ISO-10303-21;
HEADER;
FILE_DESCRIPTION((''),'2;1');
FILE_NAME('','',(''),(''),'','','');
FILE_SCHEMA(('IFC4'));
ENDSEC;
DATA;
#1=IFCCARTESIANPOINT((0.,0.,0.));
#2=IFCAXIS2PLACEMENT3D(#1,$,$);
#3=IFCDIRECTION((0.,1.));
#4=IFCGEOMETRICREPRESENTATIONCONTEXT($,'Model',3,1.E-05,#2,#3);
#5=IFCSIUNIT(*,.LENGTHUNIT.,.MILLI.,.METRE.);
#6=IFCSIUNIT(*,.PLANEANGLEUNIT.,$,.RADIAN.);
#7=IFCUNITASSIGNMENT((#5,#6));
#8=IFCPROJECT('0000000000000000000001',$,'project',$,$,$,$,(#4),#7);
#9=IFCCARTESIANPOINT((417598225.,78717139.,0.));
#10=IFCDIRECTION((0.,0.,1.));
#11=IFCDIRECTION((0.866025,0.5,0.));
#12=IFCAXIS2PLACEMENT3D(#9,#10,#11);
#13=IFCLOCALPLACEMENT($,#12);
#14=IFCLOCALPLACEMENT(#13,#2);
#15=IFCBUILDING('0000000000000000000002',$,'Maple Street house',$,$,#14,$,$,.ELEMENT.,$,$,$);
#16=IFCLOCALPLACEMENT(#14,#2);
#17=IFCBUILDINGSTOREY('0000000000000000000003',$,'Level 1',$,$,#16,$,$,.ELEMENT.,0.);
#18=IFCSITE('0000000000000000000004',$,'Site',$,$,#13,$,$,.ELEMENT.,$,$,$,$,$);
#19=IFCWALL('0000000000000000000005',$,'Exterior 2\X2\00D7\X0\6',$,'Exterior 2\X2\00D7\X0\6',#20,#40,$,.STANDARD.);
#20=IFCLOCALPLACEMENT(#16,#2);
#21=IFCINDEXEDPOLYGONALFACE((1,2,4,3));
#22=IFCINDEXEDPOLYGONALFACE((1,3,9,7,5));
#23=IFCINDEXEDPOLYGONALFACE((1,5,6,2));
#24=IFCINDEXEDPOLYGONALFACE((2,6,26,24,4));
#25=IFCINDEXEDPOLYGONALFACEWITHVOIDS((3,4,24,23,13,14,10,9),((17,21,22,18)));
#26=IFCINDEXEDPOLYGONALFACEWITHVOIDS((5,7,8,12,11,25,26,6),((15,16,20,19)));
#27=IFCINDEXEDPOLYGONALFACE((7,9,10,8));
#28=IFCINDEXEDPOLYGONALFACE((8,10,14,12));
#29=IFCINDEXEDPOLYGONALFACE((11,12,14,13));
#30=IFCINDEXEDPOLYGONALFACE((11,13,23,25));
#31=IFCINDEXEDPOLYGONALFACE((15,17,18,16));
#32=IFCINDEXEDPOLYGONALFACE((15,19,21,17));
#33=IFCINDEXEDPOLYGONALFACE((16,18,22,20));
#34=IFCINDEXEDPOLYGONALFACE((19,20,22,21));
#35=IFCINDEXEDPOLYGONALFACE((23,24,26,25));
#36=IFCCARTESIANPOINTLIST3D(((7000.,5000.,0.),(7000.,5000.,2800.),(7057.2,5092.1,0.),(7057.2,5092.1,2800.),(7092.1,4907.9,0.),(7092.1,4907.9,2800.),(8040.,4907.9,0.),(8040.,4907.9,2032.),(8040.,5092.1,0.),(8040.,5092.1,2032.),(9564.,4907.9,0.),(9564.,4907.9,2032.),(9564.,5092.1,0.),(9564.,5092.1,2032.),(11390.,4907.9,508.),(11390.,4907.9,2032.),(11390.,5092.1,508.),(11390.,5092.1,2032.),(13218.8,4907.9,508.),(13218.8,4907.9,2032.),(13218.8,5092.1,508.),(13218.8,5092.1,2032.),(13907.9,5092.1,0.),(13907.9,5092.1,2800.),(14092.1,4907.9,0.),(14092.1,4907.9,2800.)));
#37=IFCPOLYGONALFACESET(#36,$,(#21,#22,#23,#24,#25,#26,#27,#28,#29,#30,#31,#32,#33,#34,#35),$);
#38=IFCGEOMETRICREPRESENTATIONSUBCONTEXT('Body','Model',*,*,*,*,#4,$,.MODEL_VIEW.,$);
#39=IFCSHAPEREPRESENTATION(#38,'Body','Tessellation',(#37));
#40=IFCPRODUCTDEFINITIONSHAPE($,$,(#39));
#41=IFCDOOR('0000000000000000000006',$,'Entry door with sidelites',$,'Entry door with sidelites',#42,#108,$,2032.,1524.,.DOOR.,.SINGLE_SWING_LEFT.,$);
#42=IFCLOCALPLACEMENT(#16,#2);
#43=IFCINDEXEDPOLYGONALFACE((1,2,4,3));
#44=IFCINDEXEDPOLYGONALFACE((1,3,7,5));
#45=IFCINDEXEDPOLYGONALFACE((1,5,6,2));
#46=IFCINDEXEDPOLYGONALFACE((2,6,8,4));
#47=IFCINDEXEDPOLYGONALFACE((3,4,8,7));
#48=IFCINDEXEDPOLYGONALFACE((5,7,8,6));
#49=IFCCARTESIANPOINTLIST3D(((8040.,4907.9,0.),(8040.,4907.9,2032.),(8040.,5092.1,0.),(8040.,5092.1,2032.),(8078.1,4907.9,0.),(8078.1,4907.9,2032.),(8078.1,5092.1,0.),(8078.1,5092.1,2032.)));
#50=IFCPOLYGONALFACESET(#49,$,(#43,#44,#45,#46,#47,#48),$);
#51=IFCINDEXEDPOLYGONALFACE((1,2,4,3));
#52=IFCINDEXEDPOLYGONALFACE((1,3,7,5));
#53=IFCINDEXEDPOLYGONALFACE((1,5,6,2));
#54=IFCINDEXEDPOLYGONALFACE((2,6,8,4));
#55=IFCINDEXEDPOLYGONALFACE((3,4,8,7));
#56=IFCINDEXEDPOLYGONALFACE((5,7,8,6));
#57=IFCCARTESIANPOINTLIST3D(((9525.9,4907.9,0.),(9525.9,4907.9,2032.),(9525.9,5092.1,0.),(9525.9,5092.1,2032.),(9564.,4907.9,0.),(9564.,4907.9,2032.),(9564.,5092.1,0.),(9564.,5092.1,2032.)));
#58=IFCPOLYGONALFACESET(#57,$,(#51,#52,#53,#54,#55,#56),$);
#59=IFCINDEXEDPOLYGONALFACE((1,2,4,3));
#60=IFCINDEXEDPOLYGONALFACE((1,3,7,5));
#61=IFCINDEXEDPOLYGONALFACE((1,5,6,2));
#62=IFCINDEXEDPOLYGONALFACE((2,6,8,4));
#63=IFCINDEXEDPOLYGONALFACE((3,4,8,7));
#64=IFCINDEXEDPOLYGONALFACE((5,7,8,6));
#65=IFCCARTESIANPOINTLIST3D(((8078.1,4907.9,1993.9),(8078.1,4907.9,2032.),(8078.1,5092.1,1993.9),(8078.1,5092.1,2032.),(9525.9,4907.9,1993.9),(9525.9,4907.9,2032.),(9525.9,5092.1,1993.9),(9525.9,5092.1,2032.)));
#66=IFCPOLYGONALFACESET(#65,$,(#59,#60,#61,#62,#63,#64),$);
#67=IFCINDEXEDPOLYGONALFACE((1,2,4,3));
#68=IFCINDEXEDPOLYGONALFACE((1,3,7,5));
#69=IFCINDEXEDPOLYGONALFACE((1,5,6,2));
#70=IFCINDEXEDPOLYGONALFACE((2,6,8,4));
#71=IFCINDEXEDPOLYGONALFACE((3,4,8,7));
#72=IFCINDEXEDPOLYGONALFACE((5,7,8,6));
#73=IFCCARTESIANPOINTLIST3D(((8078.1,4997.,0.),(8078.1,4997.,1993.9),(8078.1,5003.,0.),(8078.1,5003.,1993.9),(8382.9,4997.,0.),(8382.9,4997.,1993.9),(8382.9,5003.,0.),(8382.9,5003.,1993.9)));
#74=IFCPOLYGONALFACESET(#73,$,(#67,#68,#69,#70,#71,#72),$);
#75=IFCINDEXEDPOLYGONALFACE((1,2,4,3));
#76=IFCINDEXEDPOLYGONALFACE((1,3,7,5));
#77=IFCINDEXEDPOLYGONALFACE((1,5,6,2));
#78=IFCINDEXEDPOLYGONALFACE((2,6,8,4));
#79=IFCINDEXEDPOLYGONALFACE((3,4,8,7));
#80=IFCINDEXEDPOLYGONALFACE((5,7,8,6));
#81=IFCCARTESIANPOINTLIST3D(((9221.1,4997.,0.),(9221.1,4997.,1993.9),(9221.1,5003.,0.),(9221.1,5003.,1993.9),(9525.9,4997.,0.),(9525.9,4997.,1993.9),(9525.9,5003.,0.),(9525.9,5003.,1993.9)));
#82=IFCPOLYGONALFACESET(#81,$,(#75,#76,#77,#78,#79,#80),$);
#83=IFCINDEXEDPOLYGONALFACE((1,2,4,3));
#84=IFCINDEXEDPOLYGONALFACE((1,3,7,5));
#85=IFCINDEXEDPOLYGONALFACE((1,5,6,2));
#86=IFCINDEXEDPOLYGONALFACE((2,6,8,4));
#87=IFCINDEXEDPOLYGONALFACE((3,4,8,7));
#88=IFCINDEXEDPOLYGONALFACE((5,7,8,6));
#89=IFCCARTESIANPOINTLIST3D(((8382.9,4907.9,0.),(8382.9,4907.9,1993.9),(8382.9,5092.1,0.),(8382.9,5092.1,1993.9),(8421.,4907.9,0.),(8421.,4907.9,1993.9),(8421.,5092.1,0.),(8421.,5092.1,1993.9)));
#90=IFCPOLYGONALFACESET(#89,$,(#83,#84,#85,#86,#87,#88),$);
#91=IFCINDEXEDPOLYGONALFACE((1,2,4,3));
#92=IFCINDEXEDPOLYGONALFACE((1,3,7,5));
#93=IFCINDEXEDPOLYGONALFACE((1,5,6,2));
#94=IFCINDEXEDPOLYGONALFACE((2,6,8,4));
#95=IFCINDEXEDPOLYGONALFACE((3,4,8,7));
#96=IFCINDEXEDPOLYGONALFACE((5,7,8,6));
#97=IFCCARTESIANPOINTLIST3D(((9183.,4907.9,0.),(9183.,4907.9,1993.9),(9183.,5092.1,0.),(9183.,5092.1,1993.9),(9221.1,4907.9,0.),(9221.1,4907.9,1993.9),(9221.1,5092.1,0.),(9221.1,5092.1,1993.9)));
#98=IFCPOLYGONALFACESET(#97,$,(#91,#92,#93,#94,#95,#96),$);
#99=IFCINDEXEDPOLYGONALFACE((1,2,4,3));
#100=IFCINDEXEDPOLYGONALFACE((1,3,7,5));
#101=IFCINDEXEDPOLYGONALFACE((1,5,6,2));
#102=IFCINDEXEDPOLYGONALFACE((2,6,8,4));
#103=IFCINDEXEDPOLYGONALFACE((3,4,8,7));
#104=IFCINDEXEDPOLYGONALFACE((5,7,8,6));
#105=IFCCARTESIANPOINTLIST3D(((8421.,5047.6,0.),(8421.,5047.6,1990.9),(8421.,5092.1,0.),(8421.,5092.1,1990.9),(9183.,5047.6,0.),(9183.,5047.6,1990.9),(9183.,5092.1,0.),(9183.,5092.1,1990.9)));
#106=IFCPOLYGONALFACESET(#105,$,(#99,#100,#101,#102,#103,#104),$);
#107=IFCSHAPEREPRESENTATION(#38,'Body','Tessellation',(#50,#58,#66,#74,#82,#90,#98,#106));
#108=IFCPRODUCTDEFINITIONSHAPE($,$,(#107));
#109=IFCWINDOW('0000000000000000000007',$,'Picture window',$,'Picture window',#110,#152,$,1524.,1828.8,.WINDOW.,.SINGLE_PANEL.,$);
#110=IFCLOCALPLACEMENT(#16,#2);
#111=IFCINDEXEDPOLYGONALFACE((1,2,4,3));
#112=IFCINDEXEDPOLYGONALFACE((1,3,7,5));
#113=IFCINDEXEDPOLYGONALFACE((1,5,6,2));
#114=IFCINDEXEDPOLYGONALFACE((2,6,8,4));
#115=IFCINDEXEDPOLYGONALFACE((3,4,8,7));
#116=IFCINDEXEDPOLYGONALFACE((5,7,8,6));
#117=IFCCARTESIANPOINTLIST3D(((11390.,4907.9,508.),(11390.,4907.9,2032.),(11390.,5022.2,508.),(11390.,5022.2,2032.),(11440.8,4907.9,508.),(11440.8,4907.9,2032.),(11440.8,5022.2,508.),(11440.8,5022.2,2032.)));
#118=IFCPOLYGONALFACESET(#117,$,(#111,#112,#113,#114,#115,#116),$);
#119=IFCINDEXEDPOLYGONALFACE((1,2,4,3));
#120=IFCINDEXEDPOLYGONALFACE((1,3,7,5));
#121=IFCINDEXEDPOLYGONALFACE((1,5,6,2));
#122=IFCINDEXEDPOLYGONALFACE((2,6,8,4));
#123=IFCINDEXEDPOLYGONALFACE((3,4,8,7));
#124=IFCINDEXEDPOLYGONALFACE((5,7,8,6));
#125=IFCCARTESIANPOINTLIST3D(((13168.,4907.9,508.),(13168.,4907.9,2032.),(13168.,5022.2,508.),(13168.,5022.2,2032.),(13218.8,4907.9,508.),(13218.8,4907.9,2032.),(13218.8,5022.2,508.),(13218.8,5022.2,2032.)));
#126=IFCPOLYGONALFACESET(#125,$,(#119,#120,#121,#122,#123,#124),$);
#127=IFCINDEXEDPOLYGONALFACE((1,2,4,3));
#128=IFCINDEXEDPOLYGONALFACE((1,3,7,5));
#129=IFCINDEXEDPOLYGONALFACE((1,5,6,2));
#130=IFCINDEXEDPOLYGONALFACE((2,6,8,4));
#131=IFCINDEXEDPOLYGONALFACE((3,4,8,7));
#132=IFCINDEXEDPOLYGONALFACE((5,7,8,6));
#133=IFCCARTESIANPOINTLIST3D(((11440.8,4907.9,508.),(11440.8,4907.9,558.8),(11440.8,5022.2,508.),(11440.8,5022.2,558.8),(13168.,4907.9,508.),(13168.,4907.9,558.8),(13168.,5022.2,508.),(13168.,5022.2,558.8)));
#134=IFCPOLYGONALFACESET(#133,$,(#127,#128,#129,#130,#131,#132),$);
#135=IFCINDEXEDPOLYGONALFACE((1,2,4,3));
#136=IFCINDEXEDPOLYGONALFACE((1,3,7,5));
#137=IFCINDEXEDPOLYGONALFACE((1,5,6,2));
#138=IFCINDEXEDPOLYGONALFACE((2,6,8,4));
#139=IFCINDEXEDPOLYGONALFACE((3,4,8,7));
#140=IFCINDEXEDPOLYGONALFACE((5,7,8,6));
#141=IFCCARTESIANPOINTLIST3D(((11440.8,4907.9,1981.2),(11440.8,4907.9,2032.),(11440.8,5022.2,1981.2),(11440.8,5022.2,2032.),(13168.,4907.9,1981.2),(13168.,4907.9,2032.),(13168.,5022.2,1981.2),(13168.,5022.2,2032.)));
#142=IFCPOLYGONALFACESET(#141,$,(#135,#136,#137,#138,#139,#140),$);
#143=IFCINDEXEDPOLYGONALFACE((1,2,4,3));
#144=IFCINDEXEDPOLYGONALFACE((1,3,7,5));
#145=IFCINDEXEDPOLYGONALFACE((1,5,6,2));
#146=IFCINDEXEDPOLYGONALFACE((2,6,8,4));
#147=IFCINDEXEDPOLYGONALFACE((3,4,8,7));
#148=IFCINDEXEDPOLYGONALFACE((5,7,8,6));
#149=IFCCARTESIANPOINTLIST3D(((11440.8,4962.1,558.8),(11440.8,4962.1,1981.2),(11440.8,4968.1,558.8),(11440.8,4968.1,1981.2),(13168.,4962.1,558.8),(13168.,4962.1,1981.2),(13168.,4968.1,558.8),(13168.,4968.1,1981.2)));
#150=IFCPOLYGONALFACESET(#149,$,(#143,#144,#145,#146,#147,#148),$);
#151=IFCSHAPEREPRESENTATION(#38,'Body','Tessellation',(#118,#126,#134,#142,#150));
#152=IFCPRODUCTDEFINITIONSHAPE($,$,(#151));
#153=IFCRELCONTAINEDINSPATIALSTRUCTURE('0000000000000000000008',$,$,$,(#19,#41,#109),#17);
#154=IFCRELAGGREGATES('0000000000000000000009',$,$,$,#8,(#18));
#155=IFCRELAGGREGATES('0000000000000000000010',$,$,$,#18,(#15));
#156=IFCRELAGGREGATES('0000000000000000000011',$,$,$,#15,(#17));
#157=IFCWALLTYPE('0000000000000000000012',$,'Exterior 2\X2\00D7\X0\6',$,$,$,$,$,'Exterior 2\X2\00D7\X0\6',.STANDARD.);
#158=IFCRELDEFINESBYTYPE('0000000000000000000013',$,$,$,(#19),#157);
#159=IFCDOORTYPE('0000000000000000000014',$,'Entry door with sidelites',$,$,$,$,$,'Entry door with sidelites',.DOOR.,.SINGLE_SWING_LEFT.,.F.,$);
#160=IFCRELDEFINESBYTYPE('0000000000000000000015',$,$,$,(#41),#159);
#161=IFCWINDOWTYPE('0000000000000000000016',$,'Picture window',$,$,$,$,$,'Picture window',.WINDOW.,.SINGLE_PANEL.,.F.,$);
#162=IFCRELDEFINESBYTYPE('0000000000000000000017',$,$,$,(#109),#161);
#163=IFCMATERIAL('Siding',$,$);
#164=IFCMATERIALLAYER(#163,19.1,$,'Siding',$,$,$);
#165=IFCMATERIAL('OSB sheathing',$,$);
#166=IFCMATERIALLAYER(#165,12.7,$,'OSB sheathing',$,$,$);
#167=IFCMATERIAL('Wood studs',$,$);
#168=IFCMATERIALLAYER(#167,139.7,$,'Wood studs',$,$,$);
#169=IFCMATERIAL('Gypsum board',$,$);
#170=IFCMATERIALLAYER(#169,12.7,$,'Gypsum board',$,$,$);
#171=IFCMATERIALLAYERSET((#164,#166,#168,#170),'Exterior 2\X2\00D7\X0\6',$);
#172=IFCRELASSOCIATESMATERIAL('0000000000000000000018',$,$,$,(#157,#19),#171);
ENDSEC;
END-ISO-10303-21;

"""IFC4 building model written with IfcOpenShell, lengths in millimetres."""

from ifc_helpers import new_model, si_unit, direction, frame, origin, origin_with_axes, place, context, subcontext, project, spatial, polyline, outline, extrude, material, layer, layer_set, layer_usage, type_object, element, fill, save


model = new_model("IFC4")

# Units and contexts
model_context = context("Model", 3, precision=1e-05, world=origin(), true_north=direction((0.0, 1.0)))
body_context = subcontext(model_context, "Body", "Model", "MODEL_VIEW")
ifc_project = project(units=[si_unit("LENGTHUNIT", "METRE", prefix="MILLI"), si_unit("PLANEANGLEUNIT", "RADIAN")], contexts=[model_context])

# Site, building, storey
site_placement = place(None, frame((417598225.0, 78717139.0, 0.0), z_axis=(0.0, 0.0, 1.0), x_axis=(0.866025, 0.5, 0.0)))
site = spatial("IfcSite", under=ifc_project, at=site_placement, Name="Site", CompositionType="ELEMENT")
building_placement = place(site_placement, origin())
building = spatial("IfcBuilding", under=site, at=building_placement, Name="Maple Street house", CompositionType="ELEMENT")
storey_placement = place(building_placement, origin())
storey = spatial("IfcBuildingStorey", under=building, at=storey_placement, Name="Level 1", CompositionType="ELEMENT", Elevation=0.0)

# Wall, openings, door, window
ifc_material_1 = material(Name="Siding")
ifc_layer_1 = layer(ifc_material_1, 19.1, Name="Siding")
ifc_material_2 = material(Name="OSB sheathing")
ifc_layer_2 = layer(ifc_material_2, 12.7, Name="OSB sheathing")
ifc_material_3 = material(Name="Wood studs")
ifc_layer_3 = layer(ifc_material_3, 139.7, Name="Wood studs")
ifc_material_4 = material(Name="Gypsum board")
ifc_layer_4 = layer(ifc_material_4, 12.7, Name="Gypsum board")
ifc_layer_set_1 = layer_set([ifc_layer_1, ifc_layer_2, ifc_layer_3, ifc_layer_4], Name="Exterior 2×6")
ifc_layer_usage_1 = layer_usage(ifc_layer_set_1, "AXIS2", "POSITIVE", -92.1)
wall_type_1 = type_object("IfcWallType", Name="Exterior 2×6", ElementType="Exterior 2×6", PredefinedType="STANDARD", material=ifc_layer_set_1)
wall_1_placement = place(storey_placement, frame((7000.0, 5000.0, 0.0), z_axis=(0.0, 0.0, 1.0), x_axis=(1.0, 0.0, 0.0)))
wall_1 = element("IfcWall", 1, at=wall_1_placement, inside=storey, type_object=wall_type_1, material=ifc_layer_usage_1, Name="Exterior 2×6", ObjectType="Exterior 2×6", PredefinedType="STANDARD", context=body_context, shape_type="SweptSolid", body=[
    extrude(outline(polyline([(92.1, -92.1), (7092.1, -92.1), (6907.9, 92.1), (57.1, 92.1), (0.0, 0.0), (92.1, -92.1)])), origin(), (0.0, 0.0, 1.0), 2800.0),
])
opening_1_placement = place(wall_1_placement, frame((1040.0, 0.0, 0.0), z_axis=(0.0, 0.0, 1.0), x_axis=(1.0, 0.0, 0.0)))
opening_1 = element("IfcOpeningElement", 2, at=opening_1_placement, cuts=wall_1, PredefinedType="OPENING", context=body_context, shape_type="SweptSolid", body=[
    extrude(outline(polyline([(0.0, -102.1), (1524.0, -102.1), (1524.0, 102.1), (0.0, 102.1), (0.0, -102.1)])), origin(), (0.0, 0.0, 1.0), 2032.0),
])
opening_2_placement = place(wall_1_placement, frame((4390.0, 0.0, 508.0), z_axis=(0.0, 0.0, 1.0), x_axis=(1.0, 0.0, 0.0)))
opening_2 = element("IfcOpeningElement", 3, at=opening_2_placement, cuts=wall_1, PredefinedType="OPENING", context=body_context, shape_type="SweptSolid", body=[
    extrude(outline(polyline([(0.0, -102.1), (1828.8, -102.1), (1828.8, 102.1), (0.0, 102.1), (0.0, -102.1)])), origin(), (0.0, 0.0, 1.0), 1524.0),
])
door_type_1 = type_object("IfcDoorType", Name="Entry door with sidelites", ElementType="Entry door with sidelites", OperationType="SINGLE_SWING_LEFT", ParameterTakesPrecedence=False, PredefinedType="DOOR")
door_1_placement = place(opening_1_placement, origin_with_axes())
door_1 = element("IfcDoor", 4, at=door_1_placement, inside=storey, type_object=door_type_1, Name="Entry door with sidelites", ObjectType="Entry door with sidelites", OperationType="SINGLE_SWING_LEFT", OverallHeight=2032.0, OverallWidth=1524.0, PredefinedType="DOOR", context=body_context, shape_type="SweptSolid", body=[
    extrude(outline(polyline([(0.0, -92.1), (38.1, -92.1), (38.1, 92.1), (0.0, 92.1), (0.0, -92.1)])), origin(), (0.0, 0.0, 1.0), 2032.0),
    extrude(outline(polyline([(1485.9, -92.1), (1524.0, -92.1), (1524.0, 92.1), (1485.9, 92.1), (1485.9, -92.1)])), origin(), (0.0, 0.0, 1.0), 2032.0),
    extrude(outline(polyline([(38.1, -92.1), (1485.9, -92.1), (1485.9, 92.1), (38.1, 92.1), (38.1, -92.1)])), frame((0.0, 0.0, 1993.9)), (0.0, 0.0, 1.0), 38.1),
    extrude(outline(polyline([(38.1, -3.0), (342.9, -3.0), (342.9, 3.0), (38.1, 3.0), (38.1, -3.0)])), origin(), (0.0, 0.0, 1.0), 1993.9),
    extrude(outline(polyline([(1181.1, -3.0), (1485.9, -3.0), (1485.9, 3.0), (1181.1, 3.0), (1181.1, -3.0)])), origin(), (0.0, 0.0, 1.0), 1993.9),
    extrude(outline(polyline([(342.9, -92.1), (381.0, -92.1), (381.0, 92.1), (342.9, 92.1), (342.9, -92.1)])), origin(), (0.0, 0.0, 1.0), 1993.9),
    extrude(outline(polyline([(1143.0, -92.1), (1181.1, -92.1), (1181.1, 92.1), (1143.0, 92.1), (1143.0, -92.1)])), origin(), (0.0, 0.0, 1.0), 1993.9),
    extrude(outline(polyline([(381.0, 47.6), (1143.0, 47.6), (1143.0, 92.1), (381.0, 92.1), (381.0, 47.6)])), origin(), (0.0, 0.0, 1.0), 1990.9),
])
fill(opening_1, door_1)
window_type_1 = type_object("IfcWindowType", Name="Picture window", ElementType="Picture window", ParameterTakesPrecedence=False, PartitioningType="SINGLE_PANEL", PredefinedType="WINDOW")
window_1_placement = place(opening_2_placement, origin_with_axes())
window_1 = element("IfcWindow", 5, at=window_1_placement, inside=storey, type_object=window_type_1, Name="Picture window", ObjectType="Picture window", OverallHeight=1524.0, OverallWidth=1828.8, PartitioningType="SINGLE_PANEL", PredefinedType="WINDOW", context=body_context, shape_type="SweptSolid", body=[
    extrude(outline(polyline([(0.0, -92.1), (50.8, -92.1), (50.8, 22.2), (0.0, 22.2), (0.0, -92.1)])), origin(), (0.0, 0.0, 1.0), 1524.0),
    extrude(outline(polyline([(1778.0, -92.1), (1828.8, -92.1), (1828.8, 22.2), (1778.0, 22.2), (1778.0, -92.1)])), origin(), (0.0, 0.0, 1.0), 1524.0),
    extrude(outline(polyline([(50.8, -92.1), (1778.0, -92.1), (1778.0, 22.2), (50.8, 22.2), (50.8, -92.1)])), origin(), (0.0, 0.0, 1.0), 50.8),
    extrude(outline(polyline([(50.8, -92.1), (1778.0, -92.1), (1778.0, 22.2), (50.8, 22.2), (50.8, -92.1)])), frame((0.0, 0.0, 1473.2)), (0.0, 0.0, 1.0), 50.8),
    extrude(outline(polyline([(50.8, -37.9), (1778.0, -37.9), (1778.0, -31.9), (50.8, -31.9), (50.8, -37.9)])), frame((0.0, 0.0, 50.8)), (0.0, 0.0, 1.0), 1422.4),
])
fill(opening_2, window_1)

save(model, "model.ifc")
